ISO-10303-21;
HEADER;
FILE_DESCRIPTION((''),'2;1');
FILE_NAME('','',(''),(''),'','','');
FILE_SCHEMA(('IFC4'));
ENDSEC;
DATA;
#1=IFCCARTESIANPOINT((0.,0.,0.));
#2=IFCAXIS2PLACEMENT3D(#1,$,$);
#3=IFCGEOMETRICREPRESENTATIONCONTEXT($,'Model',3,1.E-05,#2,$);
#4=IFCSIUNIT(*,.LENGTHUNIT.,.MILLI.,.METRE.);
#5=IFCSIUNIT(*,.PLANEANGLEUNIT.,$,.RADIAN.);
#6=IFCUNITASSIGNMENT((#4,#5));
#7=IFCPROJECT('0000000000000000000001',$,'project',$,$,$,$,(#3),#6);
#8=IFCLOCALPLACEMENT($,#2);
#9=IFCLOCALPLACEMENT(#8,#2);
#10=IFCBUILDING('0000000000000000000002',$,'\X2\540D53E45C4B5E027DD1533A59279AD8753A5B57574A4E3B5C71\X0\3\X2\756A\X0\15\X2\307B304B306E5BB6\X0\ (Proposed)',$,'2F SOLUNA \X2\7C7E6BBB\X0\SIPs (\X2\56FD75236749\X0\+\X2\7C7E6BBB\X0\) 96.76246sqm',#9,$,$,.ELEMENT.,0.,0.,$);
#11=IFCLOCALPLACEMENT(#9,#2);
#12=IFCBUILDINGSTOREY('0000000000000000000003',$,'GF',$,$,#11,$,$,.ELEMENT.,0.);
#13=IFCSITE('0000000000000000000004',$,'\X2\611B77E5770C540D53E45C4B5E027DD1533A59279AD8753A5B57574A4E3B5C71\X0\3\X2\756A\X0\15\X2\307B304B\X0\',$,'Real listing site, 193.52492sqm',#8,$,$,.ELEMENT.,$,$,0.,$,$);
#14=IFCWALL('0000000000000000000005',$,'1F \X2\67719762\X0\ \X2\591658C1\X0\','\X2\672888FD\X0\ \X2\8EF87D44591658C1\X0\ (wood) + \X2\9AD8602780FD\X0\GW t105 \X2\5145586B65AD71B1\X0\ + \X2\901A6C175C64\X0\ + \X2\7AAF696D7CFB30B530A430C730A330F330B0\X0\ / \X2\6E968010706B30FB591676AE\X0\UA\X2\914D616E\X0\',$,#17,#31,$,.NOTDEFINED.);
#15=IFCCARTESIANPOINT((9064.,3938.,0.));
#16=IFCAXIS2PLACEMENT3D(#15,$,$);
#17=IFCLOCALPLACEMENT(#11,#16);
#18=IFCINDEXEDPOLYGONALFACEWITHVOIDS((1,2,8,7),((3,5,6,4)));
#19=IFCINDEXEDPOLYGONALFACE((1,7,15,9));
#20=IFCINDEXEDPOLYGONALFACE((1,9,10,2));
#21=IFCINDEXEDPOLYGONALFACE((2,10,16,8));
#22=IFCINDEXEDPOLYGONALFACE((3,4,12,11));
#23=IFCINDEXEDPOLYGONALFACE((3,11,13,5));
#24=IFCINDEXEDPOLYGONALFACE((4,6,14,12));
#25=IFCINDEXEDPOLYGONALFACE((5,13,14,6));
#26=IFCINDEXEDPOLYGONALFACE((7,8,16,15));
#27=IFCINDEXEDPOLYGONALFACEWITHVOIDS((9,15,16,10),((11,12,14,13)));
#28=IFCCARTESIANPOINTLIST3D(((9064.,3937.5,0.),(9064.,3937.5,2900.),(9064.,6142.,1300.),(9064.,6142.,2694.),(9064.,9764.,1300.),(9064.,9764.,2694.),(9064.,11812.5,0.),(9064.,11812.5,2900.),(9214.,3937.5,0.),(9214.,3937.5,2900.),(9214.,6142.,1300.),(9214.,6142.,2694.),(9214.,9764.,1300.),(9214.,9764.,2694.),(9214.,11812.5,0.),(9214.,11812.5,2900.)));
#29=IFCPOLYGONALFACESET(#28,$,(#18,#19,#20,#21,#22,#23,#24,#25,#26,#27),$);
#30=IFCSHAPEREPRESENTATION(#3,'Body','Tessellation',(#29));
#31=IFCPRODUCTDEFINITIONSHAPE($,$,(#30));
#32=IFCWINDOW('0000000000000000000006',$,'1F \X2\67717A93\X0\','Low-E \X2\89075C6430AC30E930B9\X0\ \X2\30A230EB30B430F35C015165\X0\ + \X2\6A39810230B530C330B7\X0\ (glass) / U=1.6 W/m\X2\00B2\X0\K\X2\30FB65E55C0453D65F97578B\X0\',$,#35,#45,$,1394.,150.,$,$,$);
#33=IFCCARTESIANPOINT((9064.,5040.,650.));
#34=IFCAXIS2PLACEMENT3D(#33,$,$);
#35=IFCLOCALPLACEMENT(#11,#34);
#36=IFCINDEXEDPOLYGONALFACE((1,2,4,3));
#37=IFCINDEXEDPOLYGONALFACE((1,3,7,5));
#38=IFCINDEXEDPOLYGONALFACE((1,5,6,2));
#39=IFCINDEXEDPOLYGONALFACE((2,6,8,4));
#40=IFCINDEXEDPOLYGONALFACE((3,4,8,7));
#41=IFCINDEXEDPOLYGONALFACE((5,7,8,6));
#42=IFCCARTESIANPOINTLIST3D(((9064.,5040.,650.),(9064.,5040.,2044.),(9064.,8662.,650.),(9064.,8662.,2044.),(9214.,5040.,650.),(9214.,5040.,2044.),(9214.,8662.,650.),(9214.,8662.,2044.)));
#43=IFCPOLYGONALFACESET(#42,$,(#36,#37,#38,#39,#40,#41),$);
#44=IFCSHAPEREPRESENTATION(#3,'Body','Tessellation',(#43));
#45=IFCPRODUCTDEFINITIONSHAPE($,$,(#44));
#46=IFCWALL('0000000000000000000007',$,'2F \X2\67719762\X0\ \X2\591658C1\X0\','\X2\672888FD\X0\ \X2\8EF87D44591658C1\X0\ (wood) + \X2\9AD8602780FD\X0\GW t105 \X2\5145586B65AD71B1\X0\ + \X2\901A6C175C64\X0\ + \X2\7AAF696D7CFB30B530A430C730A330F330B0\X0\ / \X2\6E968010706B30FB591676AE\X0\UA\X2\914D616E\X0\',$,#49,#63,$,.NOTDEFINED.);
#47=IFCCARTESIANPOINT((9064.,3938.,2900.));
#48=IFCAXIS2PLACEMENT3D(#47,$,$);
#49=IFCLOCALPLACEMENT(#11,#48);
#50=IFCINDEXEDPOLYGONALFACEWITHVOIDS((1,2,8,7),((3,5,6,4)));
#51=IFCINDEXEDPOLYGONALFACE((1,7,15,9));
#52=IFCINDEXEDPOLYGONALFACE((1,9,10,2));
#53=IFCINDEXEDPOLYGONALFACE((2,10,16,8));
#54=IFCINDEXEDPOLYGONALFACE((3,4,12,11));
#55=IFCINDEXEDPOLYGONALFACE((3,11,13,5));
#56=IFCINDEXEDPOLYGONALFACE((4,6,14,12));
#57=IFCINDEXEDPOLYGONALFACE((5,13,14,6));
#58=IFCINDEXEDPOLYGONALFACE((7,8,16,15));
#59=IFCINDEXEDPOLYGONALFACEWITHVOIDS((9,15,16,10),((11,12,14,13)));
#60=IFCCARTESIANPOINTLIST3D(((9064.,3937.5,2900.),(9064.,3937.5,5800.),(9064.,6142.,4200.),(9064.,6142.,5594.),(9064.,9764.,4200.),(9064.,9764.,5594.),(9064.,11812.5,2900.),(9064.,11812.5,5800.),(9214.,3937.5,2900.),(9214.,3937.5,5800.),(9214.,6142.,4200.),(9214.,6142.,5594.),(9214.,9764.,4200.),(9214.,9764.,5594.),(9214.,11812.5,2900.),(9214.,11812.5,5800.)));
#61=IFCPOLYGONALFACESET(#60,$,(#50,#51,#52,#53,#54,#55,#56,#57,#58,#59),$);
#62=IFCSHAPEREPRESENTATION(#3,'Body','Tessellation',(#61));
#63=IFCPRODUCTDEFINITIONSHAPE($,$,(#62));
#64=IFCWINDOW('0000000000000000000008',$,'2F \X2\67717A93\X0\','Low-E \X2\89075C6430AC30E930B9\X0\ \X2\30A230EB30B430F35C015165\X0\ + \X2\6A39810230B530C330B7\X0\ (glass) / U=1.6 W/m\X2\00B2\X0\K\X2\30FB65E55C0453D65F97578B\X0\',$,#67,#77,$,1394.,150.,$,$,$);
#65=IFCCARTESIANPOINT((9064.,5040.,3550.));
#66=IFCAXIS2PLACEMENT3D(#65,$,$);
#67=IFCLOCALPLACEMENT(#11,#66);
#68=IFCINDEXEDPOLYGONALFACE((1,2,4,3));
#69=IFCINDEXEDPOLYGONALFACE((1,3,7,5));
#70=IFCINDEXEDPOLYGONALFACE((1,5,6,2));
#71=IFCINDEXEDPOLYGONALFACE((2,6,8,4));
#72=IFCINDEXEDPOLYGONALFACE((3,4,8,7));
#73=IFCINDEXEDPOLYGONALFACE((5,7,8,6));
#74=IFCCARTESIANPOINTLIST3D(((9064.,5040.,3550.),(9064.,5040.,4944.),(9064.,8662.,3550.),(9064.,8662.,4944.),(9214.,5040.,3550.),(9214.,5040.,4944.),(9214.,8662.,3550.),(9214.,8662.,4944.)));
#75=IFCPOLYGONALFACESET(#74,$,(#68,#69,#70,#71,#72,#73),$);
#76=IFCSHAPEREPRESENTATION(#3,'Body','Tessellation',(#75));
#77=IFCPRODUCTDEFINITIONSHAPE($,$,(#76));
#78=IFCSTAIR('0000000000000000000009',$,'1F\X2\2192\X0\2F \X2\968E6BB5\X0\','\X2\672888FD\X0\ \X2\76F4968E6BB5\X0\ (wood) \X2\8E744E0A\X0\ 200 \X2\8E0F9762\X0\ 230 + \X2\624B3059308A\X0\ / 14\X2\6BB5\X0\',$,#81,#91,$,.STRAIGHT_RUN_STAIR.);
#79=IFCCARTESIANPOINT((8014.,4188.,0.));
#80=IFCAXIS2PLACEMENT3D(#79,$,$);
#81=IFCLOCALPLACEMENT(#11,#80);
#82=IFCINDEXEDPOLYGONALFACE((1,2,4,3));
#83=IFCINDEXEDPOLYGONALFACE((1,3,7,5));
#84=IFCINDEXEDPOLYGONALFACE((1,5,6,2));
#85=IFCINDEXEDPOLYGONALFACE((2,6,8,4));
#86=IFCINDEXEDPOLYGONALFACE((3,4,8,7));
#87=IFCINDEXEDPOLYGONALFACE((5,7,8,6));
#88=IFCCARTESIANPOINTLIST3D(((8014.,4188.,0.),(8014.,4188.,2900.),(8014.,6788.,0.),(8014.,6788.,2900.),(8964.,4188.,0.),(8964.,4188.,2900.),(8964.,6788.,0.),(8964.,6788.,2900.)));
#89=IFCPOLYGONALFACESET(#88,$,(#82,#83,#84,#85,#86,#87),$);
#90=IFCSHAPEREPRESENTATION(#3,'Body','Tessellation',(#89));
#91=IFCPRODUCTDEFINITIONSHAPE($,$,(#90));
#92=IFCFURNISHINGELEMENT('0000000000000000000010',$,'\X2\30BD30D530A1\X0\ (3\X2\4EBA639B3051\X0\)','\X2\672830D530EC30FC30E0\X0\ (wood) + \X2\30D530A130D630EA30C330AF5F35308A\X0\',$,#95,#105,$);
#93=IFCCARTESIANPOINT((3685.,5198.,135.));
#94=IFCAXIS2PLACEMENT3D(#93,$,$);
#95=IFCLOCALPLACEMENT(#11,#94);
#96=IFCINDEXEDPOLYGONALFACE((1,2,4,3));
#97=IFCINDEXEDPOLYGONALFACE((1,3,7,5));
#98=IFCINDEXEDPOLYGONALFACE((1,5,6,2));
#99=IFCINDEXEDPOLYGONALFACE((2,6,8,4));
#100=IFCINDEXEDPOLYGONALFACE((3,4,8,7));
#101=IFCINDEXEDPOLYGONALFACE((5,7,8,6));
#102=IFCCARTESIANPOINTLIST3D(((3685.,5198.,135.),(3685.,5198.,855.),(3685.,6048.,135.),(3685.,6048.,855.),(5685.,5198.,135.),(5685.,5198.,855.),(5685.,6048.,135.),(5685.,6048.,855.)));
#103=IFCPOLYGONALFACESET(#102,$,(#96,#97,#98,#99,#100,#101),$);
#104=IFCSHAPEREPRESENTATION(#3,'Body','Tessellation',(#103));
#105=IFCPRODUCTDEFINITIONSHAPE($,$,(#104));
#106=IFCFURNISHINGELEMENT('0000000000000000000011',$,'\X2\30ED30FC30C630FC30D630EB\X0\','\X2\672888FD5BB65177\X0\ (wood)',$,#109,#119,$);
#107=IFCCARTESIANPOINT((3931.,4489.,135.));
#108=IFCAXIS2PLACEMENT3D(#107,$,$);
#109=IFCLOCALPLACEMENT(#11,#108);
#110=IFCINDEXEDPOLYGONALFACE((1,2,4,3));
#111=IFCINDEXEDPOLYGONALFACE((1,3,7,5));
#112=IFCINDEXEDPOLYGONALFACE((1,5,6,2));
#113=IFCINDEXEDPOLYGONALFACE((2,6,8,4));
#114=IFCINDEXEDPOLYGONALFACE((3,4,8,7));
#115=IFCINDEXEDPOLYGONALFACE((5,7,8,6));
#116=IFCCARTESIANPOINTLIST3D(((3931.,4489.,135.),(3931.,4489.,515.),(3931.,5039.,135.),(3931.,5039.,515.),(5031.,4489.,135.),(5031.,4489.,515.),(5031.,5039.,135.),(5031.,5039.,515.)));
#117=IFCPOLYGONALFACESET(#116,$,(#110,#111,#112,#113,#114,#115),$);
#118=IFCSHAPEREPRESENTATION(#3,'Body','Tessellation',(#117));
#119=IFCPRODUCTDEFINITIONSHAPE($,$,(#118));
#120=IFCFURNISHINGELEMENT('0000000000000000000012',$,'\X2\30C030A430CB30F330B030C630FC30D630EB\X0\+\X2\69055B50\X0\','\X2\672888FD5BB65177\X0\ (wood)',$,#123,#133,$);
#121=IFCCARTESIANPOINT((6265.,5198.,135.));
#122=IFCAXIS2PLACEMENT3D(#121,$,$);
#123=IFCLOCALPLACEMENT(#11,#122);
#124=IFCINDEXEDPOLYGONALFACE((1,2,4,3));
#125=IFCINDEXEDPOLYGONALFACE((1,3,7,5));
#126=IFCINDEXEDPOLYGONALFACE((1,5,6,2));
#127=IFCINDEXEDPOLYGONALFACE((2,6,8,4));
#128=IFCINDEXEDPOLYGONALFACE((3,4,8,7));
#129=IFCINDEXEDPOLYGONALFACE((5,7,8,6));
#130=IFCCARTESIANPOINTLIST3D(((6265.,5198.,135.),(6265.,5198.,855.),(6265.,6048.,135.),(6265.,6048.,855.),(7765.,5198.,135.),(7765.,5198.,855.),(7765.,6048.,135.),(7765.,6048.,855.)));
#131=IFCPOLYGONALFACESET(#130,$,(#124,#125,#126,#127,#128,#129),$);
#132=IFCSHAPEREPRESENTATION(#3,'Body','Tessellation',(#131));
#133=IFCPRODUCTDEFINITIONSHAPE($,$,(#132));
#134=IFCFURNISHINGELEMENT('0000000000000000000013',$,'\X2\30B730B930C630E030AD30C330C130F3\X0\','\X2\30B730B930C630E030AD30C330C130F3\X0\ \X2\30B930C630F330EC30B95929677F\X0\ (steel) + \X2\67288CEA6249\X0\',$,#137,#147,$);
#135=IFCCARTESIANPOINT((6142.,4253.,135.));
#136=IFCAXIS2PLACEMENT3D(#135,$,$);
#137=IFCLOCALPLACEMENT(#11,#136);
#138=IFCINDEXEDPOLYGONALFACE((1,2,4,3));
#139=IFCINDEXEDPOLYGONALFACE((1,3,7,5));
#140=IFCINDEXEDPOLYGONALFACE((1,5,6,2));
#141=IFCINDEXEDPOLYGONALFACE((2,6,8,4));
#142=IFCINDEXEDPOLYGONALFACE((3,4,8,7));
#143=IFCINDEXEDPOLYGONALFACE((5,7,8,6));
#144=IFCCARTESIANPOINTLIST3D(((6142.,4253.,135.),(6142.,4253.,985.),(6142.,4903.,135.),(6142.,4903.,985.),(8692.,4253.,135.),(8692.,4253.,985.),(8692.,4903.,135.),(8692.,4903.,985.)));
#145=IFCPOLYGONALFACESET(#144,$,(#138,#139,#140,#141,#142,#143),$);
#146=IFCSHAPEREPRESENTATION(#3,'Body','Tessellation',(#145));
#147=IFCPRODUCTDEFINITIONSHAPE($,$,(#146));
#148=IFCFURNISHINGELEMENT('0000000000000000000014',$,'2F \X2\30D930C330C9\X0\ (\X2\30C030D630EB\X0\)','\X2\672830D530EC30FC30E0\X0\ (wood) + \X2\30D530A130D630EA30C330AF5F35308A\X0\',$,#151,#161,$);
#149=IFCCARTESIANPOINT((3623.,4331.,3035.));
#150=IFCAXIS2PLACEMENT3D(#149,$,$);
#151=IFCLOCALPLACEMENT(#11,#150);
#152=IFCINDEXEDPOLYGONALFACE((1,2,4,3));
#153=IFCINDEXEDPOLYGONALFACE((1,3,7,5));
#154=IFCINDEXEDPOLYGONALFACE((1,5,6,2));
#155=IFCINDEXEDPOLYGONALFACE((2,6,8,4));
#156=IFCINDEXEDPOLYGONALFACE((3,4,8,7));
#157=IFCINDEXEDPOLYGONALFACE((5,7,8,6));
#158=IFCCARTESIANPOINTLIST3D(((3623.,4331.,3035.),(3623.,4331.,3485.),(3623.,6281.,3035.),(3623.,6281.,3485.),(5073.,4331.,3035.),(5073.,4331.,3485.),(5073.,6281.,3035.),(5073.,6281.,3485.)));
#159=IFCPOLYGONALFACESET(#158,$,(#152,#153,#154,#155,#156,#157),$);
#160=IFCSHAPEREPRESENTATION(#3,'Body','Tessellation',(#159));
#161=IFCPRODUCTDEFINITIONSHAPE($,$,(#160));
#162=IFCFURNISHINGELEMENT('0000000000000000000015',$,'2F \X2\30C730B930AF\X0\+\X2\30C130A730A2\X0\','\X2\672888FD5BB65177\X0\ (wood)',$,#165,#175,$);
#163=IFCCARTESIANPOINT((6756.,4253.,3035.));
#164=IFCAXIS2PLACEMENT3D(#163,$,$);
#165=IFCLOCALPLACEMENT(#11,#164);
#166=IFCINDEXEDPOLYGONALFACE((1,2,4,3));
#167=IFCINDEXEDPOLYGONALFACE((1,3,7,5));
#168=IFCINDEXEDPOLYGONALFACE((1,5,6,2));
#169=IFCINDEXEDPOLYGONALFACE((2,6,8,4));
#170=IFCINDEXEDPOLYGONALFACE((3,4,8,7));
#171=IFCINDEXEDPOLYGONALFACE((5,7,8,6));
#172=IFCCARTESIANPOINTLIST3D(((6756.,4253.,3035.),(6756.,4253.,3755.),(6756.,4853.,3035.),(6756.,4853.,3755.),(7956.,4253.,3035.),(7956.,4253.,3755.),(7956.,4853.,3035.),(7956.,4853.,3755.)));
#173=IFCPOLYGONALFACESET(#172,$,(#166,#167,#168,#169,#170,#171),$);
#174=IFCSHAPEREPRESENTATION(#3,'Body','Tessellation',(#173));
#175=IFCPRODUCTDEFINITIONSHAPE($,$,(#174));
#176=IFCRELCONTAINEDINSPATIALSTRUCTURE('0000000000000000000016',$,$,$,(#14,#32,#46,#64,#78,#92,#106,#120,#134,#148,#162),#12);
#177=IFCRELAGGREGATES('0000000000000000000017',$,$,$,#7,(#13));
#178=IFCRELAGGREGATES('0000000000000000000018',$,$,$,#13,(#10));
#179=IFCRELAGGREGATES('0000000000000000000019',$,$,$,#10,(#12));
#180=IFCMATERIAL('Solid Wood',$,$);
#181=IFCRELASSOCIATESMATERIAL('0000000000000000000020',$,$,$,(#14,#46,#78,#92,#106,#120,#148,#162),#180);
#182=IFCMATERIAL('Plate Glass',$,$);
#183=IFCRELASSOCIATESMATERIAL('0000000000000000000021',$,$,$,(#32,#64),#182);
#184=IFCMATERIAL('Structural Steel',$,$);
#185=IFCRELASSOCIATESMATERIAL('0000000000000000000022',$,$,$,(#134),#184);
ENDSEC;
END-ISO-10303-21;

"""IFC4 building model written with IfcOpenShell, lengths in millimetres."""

from ifc_helpers import new_model, si_unit, frame, frame_2d, origin, place, context, project, spatial, rectangle, extrude, material, element, fill, save


model = new_model("IFC4")

# Units and contexts
model_context = context("Model", 3, precision=1e-05, world=origin())
ifc_project = project(units=[si_unit("LENGTHUNIT", "METRE", prefix="MILLI"), si_unit("PLANEANGLEUNIT", "RADIAN")], contexts=[model_context])

# Site, building, storey
site_placement = place(None, origin())
site = spatial("IfcSite", under=ifc_project, at=site_placement, Name="愛知県名古屋市緑区大高町字坊主山3番15ほか", ObjectType="Real listing site, 193.52492sqm", CompositionType="ELEMENT", RefElevation=0.0)
building_placement = place(site_placement, origin())
building = spatial("IfcBuilding", under=site, at=building_placement, Name="名古屋市緑区大高町字坊主山3番15ほかの家 (Proposed)", ObjectType="2F SOLUNA 籾殻SIPs (国産杉+籾殻) 96.76246sqm", CompositionType="ELEMENT", ElevationOfRefHeight=0.0, ElevationOfTerrain=0.0)
storey_placement = place(building_placement, origin())
storey = spatial("IfcBuildingStorey", under=building, at=storey_placement, Name="GF", CompositionType="ELEMENT", Elevation=0.0)

# Wall, opening, window
ifc_material_1 = material(Name="Solid Wood")
wall_1_placement = place(storey_placement, frame((9064.0, 3938.0, 0.0)))
wall_1 = element("IfcWall", 1, at=wall_1_placement, inside=storey, material=ifc_material_1, Name="1F 東面 外壁", Description="木製 軸組外壁 (wood) + 高性能GW t105 充填断熱 + 通気層 + 窯業系サイディング / 準耐火・外皮UA配慮", PredefinedType="NOTDEFINED", context=model_context, shape_type="SweptSolid", body=[
    extrude(rectangle(XDim=150.0, YDim=7875.0, at=frame_2d((75.0, 3937.0))), frame((9064.0, 3938.0, 0.0)), (0.0, 0.0, 1.0), 2900.0),
])
opening_1_placement = place(storey_placement, frame((9064.0, 5040.0, 650.0)))
opening_1 = element("IfcOpeningElement", 2, at=opening_1_placement, cuts=wall_1, PredefinedType="NOTDEFINED", context=model_context, shape_type="SweptSolid", body=[
    extrude(rectangle(XDim=150.0, YDim=3622.0, at=frame_2d((75.0, 1811.0))), frame((9064.0, 5040.0, 650.0)), (0.0, 0.0, 1.0), 1394.0),
])
ifc_material_2 = material(Name="Plate Glass")
window_1_placement = place(storey_placement, frame((9064.0, 5040.0, 650.0)))
window_1 = element("IfcWindow", 3, at=window_1_placement, inside=storey, material=ifc_material_2, Name="1F 東窓", Description="Low-E 複層ガラス アルゴン封入 + 樹脂サッシ (glass) / U=1.6 W/m²K・日射取得型", OverallHeight=1394.0, OverallWidth=150.0, context=model_context, shape_type="SweptSolid", body=[
    extrude(rectangle(XDim=150.0, YDim=3622.0, at=frame_2d((75.0, 1811.0))), frame((9064.0, 5040.0, 650.0)), (0.0, 0.0, 1.0), 1394.0),
])
fill(opening_1, window_1)

# Wall, opening, window
wall_2_placement = place(storey_placement, frame((9064.0, 3938.0, 2900.0)))
wall_2 = element("IfcWall", 4, at=wall_2_placement, inside=storey, material=ifc_material_1, Name="2F 東面 外壁", Description="木製 軸組外壁 (wood) + 高性能GW t105 充填断熱 + 通気層 + 窯業系サイディング / 準耐火・外皮UA配慮", PredefinedType="NOTDEFINED", context=model_context, shape_type="SweptSolid", body=[
    extrude(rectangle(XDim=150.0, YDim=7875.0, at=frame_2d((75.0, 3937.0))), frame((9064.0, 3938.0, 2900.0)), (0.0, 0.0, 1.0), 2900.0),
])
opening_2_placement = place(storey_placement, frame((9064.0, 5040.0, 3550.0)))
opening_2 = element("IfcOpeningElement", 5, at=opening_2_placement, cuts=wall_2, PredefinedType="NOTDEFINED", context=model_context, shape_type="SweptSolid", body=[
    extrude(rectangle(XDim=150.0, YDim=3622.0, at=frame_2d((75.0, 1811.0))), frame((9064.0, 5040.0, 3550.0)), (0.0, 0.0, 1.0), 1394.0),
])
window_2_placement = place(storey_placement, frame((9064.0, 5040.0, 3550.0)))
window_2 = element("IfcWindow", 6, at=window_2_placement, inside=storey, material=ifc_material_2, Name="2F 東窓", Description="Low-E 複層ガラス アルゴン封入 + 樹脂サッシ (glass) / U=1.6 W/m²K・日射取得型", OverallHeight=1394.0, OverallWidth=150.0, context=model_context, shape_type="SweptSolid", body=[
    extrude(rectangle(XDim=150.0, YDim=3622.0, at=frame_2d((75.0, 1811.0))), frame((9064.0, 5040.0, 3550.0)), (0.0, 0.0, 1.0), 1394.0),
])
fill(opening_2, window_2)

# Stair
stair_placement = place(storey_placement, frame((8014.0, 4188.0, 0.0)))
element("IfcStair", 7, at=stair_placement, inside=storey, material=ifc_material_1, Name="1F→2F 階段", Description="木製 直階段 (wood) 蹴上 200 踏面 230 + 手すり / 14段", PredefinedType="STRAIGHT_RUN_STAIR", context=model_context, shape_type="SweptSolid", body=[
    extrude(rectangle(XDim=950.0, YDim=2600.0, at=frame_2d((475.0, 1300.0))), frame((8014.0, 4188.0, 0.0)), (0.0, 0.0, 1.0), 2900.0),
])

# Furnishing elements
furnishing_1_placement = place(storey_placement, frame((3685.0, 5198.0, 135.0)))
element("IfcFurnishingElement", 8, at=furnishing_1_placement, inside=storey, material=ifc_material_1, Name="ソファ (3人掛け)", Description="木フレーム (wood) + ファブリック張り", context=model_context, shape_type="SweptSolid", body=[
    extrude(rectangle(XDim=2000.0, YDim=850.0, at=frame_2d((1000.0, 425.0))), frame((3685.0, 5198.0, 135.0)), (0.0, 0.0, 1.0), 720.0),
])
furnishing_2_placement = place(storey_placement, frame((3931.0, 4489.0, 135.0)))
element("IfcFurnishingElement", 9, at=furnishing_2_placement, inside=storey, material=ifc_material_1, Name="ローテーブル", Description="木製家具 (wood)", context=model_context, shape_type="SweptSolid", body=[
    extrude(rectangle(XDim=1100.0, YDim=550.0, at=frame_2d((550.0, 275.0))), frame((3931.0, 4489.0, 135.0)), (0.0, 0.0, 1.0), 380.0),
])
furnishing_3_placement = place(storey_placement, frame((6265.0, 5198.0, 135.0)))
element("IfcFurnishingElement", 10, at=furnishing_3_placement, inside=storey, material=ifc_material_1, Name="ダイニングテーブル+椅子", Description="木製家具 (wood)", context=model_context, shape_type="SweptSolid", body=[
    extrude(rectangle(XDim=1500.0, YDim=850.0, at=frame_2d((750.0, 425.0))), frame((6265.0, 5198.0, 135.0)), (0.0, 0.0, 1.0), 720.0),
])
ifc_material_3 = material(Name="Structural Steel")
furnishing_4_placement = place(storey_placement, frame((6142.0, 4253.0, 135.0)))
element("IfcFurnishingElement", 11, at=furnishing_4_placement, inside=storey, material=ifc_material_3, Name="システムキッチン", Description="システムキッチン ステンレス天板 (steel) + 木質扉", context=model_context, shape_type="SweptSolid", body=[
    extrude(rectangle(XDim=2550.0, YDim=650.0, at=frame_2d((1275.0, 325.0))), frame((6142.0, 4253.0, 135.0)), (0.0, 0.0, 1.0), 850.0),
])
furnishing_5_placement = place(storey_placement, frame((3623.0, 4331.0, 3035.0)))
element("IfcFurnishingElement", 12, at=furnishing_5_placement, inside=storey, material=ifc_material_1, Name="2F ベッド (ダブル)", Description="木フレーム (wood) + ファブリック張り", context=model_context, shape_type="SweptSolid", body=[
    extrude(rectangle(XDim=1450.0, YDim=1950.0, at=frame_2d((725.0, 975.0))), frame((3623.0, 4331.0, 3035.0)), (0.0, 0.0, 1.0), 450.0),
])
furnishing_6_placement = place(storey_placement, frame((6756.0, 4253.0, 3035.0)))
element("IfcFurnishingElement", 13, at=furnishing_6_placement, inside=storey, material=ifc_material_1, Name="2F デスク+チェア", Description="木製家具 (wood)", context=model_context, shape_type="SweptSolid", body=[
    extrude(rectangle(XDim=1200.0, YDim=600.0, at=frame_2d((600.0, 300.0))), frame((6756.0, 4253.0, 3035.0)), (0.0, 0.0, 1.0), 720.0),
])

save(model, "model.ifc")
